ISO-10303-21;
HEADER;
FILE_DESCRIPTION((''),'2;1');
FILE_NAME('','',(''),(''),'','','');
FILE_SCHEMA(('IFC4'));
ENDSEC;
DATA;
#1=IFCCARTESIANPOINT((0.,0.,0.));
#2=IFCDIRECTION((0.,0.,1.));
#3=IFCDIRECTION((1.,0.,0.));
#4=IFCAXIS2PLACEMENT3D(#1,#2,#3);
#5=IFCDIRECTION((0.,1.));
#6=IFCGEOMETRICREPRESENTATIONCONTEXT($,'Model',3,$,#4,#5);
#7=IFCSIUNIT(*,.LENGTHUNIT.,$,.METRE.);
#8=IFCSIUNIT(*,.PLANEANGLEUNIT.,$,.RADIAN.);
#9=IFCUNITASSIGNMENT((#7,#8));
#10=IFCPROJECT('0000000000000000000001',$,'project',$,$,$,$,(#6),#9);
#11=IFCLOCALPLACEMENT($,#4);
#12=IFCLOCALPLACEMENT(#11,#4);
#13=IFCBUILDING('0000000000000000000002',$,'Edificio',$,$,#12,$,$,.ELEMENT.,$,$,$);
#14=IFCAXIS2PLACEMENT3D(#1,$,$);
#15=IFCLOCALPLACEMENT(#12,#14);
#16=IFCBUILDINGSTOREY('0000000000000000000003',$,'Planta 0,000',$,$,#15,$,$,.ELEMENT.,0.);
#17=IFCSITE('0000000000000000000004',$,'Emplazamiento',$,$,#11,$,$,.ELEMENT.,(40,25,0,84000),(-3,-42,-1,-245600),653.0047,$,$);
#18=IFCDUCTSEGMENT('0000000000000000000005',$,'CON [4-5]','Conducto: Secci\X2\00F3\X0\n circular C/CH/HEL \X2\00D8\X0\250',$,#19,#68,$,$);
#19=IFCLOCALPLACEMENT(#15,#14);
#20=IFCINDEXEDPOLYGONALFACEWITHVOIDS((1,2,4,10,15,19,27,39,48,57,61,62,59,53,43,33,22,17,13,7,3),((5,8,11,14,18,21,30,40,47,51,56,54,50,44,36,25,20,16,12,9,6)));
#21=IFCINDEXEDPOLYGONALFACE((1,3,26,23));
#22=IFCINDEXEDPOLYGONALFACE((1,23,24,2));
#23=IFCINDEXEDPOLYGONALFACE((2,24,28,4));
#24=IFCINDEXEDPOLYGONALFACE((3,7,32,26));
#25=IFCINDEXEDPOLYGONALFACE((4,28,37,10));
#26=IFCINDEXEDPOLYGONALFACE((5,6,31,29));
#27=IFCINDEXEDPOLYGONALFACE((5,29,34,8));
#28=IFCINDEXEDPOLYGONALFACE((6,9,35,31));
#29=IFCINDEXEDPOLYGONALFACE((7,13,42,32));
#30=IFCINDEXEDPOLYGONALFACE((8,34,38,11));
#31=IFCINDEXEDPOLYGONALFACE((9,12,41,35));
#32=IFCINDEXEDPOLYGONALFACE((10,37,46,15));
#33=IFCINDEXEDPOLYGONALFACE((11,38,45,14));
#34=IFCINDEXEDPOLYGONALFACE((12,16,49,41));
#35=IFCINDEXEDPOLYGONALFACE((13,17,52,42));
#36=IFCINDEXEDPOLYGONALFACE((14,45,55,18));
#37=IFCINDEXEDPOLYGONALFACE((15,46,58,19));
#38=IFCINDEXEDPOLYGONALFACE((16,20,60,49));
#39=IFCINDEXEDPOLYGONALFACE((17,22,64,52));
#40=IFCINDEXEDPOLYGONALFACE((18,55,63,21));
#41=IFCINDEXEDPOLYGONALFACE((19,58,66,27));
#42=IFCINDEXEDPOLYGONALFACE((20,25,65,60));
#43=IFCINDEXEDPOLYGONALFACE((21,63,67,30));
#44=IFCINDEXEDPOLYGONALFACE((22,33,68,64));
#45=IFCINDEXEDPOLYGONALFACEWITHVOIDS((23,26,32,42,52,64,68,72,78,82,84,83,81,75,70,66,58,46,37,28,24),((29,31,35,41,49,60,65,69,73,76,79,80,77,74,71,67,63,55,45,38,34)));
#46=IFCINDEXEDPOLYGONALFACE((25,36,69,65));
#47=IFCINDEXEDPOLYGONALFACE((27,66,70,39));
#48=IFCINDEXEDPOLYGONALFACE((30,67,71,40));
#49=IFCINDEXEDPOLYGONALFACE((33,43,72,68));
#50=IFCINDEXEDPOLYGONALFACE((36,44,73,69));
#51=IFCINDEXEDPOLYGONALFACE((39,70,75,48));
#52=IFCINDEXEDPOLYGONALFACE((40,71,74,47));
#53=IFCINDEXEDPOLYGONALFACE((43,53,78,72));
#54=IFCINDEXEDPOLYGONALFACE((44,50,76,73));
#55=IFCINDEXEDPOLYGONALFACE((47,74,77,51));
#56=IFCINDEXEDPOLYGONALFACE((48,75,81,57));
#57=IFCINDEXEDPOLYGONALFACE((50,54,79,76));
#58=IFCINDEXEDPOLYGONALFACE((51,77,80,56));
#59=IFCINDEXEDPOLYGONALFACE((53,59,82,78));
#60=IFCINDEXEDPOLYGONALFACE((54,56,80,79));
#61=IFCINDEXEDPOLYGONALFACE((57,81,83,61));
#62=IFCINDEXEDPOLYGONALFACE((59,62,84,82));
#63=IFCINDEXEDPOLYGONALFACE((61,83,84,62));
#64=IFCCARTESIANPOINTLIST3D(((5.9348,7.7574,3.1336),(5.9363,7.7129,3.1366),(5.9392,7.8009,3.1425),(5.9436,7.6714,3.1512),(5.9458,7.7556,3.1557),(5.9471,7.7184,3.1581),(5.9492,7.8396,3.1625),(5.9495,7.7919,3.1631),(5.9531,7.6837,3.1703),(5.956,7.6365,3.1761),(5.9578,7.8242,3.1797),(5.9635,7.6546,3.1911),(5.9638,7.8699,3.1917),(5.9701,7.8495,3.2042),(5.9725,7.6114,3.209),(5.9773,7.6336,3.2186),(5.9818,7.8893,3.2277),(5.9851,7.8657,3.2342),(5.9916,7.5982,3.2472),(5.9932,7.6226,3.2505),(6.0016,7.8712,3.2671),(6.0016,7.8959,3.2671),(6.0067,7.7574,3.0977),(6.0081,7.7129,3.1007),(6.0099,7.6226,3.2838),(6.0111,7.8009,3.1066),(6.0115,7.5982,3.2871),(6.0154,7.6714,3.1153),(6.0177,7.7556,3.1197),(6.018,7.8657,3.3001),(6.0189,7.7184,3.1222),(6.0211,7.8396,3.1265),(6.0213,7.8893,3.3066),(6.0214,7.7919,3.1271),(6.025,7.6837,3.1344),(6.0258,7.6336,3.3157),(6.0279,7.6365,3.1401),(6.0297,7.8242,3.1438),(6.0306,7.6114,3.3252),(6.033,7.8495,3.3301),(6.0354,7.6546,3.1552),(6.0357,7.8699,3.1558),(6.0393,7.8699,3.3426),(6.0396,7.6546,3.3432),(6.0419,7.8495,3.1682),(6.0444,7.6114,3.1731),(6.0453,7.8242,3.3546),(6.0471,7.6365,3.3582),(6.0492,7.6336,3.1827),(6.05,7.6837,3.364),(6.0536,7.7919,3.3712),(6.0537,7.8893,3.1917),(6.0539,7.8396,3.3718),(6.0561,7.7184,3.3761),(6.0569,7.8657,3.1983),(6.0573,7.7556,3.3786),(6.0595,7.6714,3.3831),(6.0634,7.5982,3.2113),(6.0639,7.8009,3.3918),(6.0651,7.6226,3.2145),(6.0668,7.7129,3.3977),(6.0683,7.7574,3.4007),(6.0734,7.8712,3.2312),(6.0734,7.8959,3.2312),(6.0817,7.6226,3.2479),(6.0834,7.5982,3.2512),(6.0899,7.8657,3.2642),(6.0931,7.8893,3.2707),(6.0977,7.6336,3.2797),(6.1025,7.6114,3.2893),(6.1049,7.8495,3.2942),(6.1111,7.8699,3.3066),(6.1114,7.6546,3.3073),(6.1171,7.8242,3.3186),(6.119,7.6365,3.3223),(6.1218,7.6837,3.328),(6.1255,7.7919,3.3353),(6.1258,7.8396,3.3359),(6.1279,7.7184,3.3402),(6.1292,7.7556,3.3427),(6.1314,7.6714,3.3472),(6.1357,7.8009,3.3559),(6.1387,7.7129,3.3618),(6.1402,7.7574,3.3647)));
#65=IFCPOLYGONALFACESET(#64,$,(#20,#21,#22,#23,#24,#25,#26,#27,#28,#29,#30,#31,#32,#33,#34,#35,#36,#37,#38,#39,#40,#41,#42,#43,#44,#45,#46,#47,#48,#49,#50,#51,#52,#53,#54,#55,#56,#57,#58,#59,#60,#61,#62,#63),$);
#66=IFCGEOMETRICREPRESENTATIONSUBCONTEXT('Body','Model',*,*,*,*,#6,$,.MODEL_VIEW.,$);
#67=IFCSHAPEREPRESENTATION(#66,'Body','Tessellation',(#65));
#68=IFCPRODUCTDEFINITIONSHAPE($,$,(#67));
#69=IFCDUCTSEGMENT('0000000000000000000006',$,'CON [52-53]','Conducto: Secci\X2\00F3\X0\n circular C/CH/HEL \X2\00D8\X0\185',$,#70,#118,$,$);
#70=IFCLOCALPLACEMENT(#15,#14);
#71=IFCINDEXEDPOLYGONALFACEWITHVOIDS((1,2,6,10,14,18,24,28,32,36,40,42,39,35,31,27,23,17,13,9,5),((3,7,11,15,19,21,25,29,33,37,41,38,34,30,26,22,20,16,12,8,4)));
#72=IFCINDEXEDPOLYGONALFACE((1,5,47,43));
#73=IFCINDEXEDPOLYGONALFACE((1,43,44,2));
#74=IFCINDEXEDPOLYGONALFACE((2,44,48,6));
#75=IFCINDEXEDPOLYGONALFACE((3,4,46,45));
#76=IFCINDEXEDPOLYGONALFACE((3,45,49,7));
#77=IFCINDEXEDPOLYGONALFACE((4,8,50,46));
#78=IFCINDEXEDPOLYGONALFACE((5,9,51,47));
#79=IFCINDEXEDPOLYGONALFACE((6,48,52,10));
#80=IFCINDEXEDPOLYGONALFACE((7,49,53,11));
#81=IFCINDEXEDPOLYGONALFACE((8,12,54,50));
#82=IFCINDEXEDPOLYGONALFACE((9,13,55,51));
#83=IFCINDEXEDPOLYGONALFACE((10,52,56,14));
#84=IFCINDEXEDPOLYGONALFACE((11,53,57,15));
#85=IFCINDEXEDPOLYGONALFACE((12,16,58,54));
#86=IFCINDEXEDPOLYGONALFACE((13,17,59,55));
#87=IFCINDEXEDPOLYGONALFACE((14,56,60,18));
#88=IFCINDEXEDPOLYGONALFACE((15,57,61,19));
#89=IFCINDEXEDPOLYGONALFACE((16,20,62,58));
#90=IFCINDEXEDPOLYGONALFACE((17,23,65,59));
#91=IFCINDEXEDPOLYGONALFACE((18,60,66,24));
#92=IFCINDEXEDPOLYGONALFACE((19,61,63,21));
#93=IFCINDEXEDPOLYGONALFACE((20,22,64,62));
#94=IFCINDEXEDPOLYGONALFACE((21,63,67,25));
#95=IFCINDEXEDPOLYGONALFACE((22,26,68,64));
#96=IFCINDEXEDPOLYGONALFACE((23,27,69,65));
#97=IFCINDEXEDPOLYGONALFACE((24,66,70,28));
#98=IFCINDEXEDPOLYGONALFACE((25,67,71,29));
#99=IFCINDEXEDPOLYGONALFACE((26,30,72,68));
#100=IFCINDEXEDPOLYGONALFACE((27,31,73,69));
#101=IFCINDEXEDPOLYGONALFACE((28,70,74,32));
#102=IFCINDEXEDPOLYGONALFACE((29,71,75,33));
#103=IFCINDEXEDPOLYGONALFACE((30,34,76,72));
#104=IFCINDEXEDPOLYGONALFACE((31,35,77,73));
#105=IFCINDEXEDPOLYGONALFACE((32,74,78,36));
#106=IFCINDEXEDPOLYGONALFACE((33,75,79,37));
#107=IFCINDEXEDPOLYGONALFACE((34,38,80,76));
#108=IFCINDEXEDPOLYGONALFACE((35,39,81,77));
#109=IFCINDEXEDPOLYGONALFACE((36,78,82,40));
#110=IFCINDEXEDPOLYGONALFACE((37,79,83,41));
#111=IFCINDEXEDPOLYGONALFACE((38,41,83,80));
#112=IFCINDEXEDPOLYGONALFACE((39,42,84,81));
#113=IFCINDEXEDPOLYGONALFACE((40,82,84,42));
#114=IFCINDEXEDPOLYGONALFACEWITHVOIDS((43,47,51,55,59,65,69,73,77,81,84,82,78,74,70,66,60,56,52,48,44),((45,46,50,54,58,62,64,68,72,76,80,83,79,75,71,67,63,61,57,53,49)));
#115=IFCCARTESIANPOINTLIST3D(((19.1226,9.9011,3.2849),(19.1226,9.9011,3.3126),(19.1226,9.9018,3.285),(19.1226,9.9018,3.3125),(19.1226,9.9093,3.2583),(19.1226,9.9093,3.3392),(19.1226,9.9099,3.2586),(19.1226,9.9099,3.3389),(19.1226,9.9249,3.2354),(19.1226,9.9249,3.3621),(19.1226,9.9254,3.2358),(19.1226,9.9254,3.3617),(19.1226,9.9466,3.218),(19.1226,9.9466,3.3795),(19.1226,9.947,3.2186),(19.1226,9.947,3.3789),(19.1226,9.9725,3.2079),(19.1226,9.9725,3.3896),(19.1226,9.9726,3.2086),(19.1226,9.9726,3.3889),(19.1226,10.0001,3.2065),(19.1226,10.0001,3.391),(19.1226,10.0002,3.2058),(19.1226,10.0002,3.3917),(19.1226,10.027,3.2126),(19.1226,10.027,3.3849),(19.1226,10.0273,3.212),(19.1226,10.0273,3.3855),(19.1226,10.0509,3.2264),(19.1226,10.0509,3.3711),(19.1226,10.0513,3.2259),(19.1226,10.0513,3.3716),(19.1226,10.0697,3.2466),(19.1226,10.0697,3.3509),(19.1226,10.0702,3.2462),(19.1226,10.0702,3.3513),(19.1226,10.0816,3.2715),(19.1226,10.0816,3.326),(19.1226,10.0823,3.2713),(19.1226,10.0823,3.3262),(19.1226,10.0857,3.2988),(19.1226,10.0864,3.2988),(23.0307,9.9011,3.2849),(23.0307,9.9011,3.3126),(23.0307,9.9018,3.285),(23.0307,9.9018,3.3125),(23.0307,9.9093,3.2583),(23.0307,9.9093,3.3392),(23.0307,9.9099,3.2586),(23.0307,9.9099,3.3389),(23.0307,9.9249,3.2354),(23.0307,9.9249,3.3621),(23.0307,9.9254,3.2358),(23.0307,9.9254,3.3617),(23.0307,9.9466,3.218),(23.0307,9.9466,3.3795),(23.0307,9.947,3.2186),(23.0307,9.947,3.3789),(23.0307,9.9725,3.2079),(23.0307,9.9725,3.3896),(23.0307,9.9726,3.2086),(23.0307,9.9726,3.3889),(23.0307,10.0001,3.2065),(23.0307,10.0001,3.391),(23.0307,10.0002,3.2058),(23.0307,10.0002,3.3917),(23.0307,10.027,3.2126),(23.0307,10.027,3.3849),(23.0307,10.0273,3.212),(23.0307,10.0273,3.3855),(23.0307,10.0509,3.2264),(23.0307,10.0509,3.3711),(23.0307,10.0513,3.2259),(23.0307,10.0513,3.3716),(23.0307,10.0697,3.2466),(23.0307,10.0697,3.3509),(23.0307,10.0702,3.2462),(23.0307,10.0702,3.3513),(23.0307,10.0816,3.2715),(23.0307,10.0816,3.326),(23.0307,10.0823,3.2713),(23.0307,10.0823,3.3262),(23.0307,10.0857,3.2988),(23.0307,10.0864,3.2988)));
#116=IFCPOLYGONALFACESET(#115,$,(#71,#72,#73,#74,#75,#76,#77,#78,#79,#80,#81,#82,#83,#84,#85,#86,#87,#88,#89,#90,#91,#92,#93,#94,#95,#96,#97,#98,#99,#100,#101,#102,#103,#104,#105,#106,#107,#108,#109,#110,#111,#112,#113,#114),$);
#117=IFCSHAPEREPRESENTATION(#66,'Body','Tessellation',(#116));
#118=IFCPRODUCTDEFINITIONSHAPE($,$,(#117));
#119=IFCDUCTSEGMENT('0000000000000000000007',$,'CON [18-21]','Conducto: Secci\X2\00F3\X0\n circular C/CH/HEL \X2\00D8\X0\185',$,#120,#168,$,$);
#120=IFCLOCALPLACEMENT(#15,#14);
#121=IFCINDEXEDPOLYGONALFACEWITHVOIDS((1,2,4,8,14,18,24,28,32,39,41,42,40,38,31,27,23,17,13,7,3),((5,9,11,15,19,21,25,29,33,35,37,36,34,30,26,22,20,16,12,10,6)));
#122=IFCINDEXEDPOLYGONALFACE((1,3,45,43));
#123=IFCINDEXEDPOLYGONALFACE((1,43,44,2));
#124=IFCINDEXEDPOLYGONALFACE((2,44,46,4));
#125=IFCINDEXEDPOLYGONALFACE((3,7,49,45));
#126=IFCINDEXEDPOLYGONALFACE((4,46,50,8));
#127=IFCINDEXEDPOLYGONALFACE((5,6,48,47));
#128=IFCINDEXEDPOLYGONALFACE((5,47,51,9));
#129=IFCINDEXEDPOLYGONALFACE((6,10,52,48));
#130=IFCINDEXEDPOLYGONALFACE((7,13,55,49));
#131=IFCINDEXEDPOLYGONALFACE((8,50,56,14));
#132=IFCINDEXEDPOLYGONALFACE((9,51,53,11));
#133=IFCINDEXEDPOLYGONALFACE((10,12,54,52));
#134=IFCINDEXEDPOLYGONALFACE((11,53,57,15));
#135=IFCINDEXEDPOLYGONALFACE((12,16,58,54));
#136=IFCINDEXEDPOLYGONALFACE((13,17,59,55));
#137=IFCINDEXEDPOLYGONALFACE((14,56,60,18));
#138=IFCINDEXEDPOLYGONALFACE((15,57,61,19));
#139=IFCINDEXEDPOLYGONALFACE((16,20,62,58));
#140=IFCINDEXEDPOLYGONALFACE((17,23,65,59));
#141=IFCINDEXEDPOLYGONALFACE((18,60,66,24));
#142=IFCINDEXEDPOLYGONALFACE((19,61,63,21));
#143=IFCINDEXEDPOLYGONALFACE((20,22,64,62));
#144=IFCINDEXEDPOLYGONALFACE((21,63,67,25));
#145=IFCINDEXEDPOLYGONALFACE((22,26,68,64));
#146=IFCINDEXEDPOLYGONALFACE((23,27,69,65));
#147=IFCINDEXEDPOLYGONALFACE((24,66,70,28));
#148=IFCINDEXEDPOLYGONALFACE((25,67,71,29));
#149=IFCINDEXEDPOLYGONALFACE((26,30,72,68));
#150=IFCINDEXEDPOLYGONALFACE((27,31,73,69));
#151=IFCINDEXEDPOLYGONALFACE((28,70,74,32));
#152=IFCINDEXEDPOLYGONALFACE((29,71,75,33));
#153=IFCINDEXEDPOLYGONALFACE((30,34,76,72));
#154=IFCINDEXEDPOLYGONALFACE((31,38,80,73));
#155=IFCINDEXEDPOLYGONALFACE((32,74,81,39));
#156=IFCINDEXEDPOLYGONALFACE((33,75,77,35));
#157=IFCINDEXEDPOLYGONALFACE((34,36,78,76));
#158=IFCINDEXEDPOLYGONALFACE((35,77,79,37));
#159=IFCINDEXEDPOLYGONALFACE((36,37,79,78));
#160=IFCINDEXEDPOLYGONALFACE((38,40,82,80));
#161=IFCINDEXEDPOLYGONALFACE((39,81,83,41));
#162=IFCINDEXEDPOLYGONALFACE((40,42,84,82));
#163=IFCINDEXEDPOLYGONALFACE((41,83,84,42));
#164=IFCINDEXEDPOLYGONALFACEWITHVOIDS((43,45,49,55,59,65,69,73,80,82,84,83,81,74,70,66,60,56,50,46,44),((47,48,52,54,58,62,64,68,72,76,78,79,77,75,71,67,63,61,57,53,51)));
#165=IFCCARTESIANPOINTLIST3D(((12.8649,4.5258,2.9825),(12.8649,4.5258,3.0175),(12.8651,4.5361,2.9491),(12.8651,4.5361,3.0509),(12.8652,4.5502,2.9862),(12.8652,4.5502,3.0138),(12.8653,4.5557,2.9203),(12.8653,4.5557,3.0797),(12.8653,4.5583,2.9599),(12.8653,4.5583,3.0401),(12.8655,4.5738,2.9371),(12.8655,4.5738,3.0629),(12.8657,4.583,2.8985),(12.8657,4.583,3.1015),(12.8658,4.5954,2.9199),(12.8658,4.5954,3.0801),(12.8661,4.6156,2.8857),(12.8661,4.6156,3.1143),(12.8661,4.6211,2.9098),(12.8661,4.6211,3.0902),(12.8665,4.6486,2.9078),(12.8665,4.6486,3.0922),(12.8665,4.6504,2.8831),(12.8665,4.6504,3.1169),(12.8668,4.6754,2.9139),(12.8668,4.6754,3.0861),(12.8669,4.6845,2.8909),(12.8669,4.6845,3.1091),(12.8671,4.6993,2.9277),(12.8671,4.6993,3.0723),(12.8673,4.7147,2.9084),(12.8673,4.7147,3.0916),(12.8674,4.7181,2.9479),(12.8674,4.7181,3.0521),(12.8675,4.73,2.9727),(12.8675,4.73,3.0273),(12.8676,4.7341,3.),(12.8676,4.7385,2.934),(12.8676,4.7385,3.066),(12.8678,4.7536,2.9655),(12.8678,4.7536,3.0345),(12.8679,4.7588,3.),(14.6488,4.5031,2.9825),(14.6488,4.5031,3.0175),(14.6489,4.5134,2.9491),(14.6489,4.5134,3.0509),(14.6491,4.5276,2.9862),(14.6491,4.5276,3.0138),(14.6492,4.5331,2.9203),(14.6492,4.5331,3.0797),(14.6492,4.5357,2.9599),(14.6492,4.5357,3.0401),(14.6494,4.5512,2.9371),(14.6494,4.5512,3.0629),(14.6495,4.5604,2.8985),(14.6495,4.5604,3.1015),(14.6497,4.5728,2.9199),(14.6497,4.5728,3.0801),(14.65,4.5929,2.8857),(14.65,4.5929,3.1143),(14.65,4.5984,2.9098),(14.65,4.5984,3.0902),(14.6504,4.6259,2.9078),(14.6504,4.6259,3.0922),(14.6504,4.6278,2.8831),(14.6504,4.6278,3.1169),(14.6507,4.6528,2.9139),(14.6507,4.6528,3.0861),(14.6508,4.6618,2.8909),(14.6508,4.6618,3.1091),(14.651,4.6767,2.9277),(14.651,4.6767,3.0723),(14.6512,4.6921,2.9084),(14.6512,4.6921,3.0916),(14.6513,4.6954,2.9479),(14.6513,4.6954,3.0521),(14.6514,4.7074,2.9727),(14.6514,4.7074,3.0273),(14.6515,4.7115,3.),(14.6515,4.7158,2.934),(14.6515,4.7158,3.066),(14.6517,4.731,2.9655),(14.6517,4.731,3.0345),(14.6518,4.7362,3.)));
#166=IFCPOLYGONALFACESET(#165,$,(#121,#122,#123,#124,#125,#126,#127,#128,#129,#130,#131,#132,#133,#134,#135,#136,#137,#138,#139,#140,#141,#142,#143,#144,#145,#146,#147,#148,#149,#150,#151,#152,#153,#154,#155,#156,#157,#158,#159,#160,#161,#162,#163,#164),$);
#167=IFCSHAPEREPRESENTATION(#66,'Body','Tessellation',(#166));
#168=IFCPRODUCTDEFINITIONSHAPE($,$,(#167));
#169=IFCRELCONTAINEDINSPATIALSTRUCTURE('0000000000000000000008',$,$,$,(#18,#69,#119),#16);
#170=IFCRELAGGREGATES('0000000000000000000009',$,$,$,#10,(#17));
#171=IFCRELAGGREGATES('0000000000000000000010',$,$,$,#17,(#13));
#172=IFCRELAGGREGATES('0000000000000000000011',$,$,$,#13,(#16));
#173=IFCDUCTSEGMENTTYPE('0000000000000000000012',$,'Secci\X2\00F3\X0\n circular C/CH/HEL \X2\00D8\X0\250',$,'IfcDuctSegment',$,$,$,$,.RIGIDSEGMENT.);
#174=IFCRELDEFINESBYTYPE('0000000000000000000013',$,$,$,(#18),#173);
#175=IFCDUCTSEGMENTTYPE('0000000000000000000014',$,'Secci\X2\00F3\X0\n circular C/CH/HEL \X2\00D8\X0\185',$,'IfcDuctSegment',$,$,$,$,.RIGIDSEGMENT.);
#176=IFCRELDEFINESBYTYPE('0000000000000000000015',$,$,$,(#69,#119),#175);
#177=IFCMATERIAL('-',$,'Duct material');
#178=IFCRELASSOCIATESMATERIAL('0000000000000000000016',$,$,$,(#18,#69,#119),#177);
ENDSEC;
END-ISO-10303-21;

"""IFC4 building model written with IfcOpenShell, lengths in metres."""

from ifc_helpers import new_model, si_unit, direction, frame, origin, origin_with_axes, origin_2d_with_axis, place, context, subcontext, project, spatial, hollow_circle, extrude, material, type_object, element, save


model = new_model("IFC4")

# Units and contexts
model_context = context("Model", 3, world=origin_with_axes(), true_north=direction((0.0, 1.0)))
body_context = subcontext(model_context, "Body", "Model", "MODEL_VIEW")
ifc_project = project(units=[si_unit("LENGTHUNIT", "METRE"), si_unit("PLANEANGLEUNIT", "RADIAN")], contexts=[model_context])

# Site, building, storey
site_placement = place(None, origin_with_axes())
site = spatial("IfcSite", under=ifc_project, at=site_placement, Name="Emplazamiento", CompositionType="ELEMENT", RefLatitude=(40, 25, 0, 84000), RefLongitude=(-3, -42, -1, -245600), RefElevation=653.0047)
building_placement = place(site_placement, origin_with_axes())
building = spatial("IfcBuilding", under=site, at=building_placement, Name="Edificio", CompositionType="ELEMENT")
storey_placement = place(building_placement, origin())
storey = spatial("IfcBuildingStorey", under=building, at=storey_placement, Name="Planta 0,000", CompositionType="ELEMENT", Elevation=0.0)

# Shared definitions
ifc_material_1 = material(Name="-", Category="Duct material")

# Duct segments
duct_segment_type_1 = type_object("IfcDuctSegmentType", Name="Sección circular C/CH/HEL Ø250", ApplicableOccurrence="IfcDuctSegment", PredefinedType="RIGIDSEGMENT")
duct_segment_1_placement = place(storey_placement, origin_with_axes())
element("IfcDuctSegment", 1, at=duct_segment_1_placement, inside=storey, type_object=duct_segment_type_1, material=ifc_material_1, Name="CON [4-5]", Description="Conducto: Sección circular C/CH/HEL Ø250", context=body_context, shape_type="SweptSolid", body=[
    extrude(hollow_circle(Radius=0.1497, WallThickness=0.0247, at=origin_2d_with_axis()), frame((6.0016, 7.7462, 3.2671), z_axis=(0.894427, 0.0, -0.447214), x_axis=(0.0, 1.0, 0.0)), (0.0, 0.0, 1.0), 0.0803),
])
duct_segment_type_2 = type_object("IfcDuctSegmentType", Name="Sección circular C/CH/HEL Ø185", ApplicableOccurrence="IfcDuctSegment", PredefinedType="RIGIDSEGMENT")
duct_segment_2_placement = place(storey_placement, origin_with_axes())
element("IfcDuctSegment", 2, at=duct_segment_2_placement, inside=storey, type_object=duct_segment_type_2, material=ifc_material_1, Name="CON [52-53]", Description="Conducto: Sección circular C/CH/HEL Ø185", context=body_context, shape_type="SweptSolid", body=[
    extrude(hollow_circle(Radius=0.0932, WallThickness=0.0007, at=origin_2d_with_axis()), frame((19.1226, 9.9932, 3.2988), z_axis=(1.0, 0.0, 0.0), x_axis=(0.0, 1.0, 0.0)), (0.0, 0.0, 1.0), 3.9081),
])
duct_segment_3_placement = place(storey_placement, origin_with_axes())
element("IfcDuctSegment", 3, at=duct_segment_3_placement, inside=storey, type_object=duct_segment_type_2, material=ifc_material_1, Name="CON [18-21]", Description="Conducto: Sección circular C/CH/HEL Ø185", context=body_context, shape_type="SweptSolid", body=[
    extrude(hollow_circle(Radius=0.1172, WallThickness=0.0247, at=origin_2d_with_axis()), frame((12.8664, 4.6416, 3.0), z_axis=(0.99992, -0.01268, 0.0), x_axis=(0.01268, 0.99992, 0.0)), (0.0, 0.0, 1.0), 1.784),
])

save(model, "model.ifc")
